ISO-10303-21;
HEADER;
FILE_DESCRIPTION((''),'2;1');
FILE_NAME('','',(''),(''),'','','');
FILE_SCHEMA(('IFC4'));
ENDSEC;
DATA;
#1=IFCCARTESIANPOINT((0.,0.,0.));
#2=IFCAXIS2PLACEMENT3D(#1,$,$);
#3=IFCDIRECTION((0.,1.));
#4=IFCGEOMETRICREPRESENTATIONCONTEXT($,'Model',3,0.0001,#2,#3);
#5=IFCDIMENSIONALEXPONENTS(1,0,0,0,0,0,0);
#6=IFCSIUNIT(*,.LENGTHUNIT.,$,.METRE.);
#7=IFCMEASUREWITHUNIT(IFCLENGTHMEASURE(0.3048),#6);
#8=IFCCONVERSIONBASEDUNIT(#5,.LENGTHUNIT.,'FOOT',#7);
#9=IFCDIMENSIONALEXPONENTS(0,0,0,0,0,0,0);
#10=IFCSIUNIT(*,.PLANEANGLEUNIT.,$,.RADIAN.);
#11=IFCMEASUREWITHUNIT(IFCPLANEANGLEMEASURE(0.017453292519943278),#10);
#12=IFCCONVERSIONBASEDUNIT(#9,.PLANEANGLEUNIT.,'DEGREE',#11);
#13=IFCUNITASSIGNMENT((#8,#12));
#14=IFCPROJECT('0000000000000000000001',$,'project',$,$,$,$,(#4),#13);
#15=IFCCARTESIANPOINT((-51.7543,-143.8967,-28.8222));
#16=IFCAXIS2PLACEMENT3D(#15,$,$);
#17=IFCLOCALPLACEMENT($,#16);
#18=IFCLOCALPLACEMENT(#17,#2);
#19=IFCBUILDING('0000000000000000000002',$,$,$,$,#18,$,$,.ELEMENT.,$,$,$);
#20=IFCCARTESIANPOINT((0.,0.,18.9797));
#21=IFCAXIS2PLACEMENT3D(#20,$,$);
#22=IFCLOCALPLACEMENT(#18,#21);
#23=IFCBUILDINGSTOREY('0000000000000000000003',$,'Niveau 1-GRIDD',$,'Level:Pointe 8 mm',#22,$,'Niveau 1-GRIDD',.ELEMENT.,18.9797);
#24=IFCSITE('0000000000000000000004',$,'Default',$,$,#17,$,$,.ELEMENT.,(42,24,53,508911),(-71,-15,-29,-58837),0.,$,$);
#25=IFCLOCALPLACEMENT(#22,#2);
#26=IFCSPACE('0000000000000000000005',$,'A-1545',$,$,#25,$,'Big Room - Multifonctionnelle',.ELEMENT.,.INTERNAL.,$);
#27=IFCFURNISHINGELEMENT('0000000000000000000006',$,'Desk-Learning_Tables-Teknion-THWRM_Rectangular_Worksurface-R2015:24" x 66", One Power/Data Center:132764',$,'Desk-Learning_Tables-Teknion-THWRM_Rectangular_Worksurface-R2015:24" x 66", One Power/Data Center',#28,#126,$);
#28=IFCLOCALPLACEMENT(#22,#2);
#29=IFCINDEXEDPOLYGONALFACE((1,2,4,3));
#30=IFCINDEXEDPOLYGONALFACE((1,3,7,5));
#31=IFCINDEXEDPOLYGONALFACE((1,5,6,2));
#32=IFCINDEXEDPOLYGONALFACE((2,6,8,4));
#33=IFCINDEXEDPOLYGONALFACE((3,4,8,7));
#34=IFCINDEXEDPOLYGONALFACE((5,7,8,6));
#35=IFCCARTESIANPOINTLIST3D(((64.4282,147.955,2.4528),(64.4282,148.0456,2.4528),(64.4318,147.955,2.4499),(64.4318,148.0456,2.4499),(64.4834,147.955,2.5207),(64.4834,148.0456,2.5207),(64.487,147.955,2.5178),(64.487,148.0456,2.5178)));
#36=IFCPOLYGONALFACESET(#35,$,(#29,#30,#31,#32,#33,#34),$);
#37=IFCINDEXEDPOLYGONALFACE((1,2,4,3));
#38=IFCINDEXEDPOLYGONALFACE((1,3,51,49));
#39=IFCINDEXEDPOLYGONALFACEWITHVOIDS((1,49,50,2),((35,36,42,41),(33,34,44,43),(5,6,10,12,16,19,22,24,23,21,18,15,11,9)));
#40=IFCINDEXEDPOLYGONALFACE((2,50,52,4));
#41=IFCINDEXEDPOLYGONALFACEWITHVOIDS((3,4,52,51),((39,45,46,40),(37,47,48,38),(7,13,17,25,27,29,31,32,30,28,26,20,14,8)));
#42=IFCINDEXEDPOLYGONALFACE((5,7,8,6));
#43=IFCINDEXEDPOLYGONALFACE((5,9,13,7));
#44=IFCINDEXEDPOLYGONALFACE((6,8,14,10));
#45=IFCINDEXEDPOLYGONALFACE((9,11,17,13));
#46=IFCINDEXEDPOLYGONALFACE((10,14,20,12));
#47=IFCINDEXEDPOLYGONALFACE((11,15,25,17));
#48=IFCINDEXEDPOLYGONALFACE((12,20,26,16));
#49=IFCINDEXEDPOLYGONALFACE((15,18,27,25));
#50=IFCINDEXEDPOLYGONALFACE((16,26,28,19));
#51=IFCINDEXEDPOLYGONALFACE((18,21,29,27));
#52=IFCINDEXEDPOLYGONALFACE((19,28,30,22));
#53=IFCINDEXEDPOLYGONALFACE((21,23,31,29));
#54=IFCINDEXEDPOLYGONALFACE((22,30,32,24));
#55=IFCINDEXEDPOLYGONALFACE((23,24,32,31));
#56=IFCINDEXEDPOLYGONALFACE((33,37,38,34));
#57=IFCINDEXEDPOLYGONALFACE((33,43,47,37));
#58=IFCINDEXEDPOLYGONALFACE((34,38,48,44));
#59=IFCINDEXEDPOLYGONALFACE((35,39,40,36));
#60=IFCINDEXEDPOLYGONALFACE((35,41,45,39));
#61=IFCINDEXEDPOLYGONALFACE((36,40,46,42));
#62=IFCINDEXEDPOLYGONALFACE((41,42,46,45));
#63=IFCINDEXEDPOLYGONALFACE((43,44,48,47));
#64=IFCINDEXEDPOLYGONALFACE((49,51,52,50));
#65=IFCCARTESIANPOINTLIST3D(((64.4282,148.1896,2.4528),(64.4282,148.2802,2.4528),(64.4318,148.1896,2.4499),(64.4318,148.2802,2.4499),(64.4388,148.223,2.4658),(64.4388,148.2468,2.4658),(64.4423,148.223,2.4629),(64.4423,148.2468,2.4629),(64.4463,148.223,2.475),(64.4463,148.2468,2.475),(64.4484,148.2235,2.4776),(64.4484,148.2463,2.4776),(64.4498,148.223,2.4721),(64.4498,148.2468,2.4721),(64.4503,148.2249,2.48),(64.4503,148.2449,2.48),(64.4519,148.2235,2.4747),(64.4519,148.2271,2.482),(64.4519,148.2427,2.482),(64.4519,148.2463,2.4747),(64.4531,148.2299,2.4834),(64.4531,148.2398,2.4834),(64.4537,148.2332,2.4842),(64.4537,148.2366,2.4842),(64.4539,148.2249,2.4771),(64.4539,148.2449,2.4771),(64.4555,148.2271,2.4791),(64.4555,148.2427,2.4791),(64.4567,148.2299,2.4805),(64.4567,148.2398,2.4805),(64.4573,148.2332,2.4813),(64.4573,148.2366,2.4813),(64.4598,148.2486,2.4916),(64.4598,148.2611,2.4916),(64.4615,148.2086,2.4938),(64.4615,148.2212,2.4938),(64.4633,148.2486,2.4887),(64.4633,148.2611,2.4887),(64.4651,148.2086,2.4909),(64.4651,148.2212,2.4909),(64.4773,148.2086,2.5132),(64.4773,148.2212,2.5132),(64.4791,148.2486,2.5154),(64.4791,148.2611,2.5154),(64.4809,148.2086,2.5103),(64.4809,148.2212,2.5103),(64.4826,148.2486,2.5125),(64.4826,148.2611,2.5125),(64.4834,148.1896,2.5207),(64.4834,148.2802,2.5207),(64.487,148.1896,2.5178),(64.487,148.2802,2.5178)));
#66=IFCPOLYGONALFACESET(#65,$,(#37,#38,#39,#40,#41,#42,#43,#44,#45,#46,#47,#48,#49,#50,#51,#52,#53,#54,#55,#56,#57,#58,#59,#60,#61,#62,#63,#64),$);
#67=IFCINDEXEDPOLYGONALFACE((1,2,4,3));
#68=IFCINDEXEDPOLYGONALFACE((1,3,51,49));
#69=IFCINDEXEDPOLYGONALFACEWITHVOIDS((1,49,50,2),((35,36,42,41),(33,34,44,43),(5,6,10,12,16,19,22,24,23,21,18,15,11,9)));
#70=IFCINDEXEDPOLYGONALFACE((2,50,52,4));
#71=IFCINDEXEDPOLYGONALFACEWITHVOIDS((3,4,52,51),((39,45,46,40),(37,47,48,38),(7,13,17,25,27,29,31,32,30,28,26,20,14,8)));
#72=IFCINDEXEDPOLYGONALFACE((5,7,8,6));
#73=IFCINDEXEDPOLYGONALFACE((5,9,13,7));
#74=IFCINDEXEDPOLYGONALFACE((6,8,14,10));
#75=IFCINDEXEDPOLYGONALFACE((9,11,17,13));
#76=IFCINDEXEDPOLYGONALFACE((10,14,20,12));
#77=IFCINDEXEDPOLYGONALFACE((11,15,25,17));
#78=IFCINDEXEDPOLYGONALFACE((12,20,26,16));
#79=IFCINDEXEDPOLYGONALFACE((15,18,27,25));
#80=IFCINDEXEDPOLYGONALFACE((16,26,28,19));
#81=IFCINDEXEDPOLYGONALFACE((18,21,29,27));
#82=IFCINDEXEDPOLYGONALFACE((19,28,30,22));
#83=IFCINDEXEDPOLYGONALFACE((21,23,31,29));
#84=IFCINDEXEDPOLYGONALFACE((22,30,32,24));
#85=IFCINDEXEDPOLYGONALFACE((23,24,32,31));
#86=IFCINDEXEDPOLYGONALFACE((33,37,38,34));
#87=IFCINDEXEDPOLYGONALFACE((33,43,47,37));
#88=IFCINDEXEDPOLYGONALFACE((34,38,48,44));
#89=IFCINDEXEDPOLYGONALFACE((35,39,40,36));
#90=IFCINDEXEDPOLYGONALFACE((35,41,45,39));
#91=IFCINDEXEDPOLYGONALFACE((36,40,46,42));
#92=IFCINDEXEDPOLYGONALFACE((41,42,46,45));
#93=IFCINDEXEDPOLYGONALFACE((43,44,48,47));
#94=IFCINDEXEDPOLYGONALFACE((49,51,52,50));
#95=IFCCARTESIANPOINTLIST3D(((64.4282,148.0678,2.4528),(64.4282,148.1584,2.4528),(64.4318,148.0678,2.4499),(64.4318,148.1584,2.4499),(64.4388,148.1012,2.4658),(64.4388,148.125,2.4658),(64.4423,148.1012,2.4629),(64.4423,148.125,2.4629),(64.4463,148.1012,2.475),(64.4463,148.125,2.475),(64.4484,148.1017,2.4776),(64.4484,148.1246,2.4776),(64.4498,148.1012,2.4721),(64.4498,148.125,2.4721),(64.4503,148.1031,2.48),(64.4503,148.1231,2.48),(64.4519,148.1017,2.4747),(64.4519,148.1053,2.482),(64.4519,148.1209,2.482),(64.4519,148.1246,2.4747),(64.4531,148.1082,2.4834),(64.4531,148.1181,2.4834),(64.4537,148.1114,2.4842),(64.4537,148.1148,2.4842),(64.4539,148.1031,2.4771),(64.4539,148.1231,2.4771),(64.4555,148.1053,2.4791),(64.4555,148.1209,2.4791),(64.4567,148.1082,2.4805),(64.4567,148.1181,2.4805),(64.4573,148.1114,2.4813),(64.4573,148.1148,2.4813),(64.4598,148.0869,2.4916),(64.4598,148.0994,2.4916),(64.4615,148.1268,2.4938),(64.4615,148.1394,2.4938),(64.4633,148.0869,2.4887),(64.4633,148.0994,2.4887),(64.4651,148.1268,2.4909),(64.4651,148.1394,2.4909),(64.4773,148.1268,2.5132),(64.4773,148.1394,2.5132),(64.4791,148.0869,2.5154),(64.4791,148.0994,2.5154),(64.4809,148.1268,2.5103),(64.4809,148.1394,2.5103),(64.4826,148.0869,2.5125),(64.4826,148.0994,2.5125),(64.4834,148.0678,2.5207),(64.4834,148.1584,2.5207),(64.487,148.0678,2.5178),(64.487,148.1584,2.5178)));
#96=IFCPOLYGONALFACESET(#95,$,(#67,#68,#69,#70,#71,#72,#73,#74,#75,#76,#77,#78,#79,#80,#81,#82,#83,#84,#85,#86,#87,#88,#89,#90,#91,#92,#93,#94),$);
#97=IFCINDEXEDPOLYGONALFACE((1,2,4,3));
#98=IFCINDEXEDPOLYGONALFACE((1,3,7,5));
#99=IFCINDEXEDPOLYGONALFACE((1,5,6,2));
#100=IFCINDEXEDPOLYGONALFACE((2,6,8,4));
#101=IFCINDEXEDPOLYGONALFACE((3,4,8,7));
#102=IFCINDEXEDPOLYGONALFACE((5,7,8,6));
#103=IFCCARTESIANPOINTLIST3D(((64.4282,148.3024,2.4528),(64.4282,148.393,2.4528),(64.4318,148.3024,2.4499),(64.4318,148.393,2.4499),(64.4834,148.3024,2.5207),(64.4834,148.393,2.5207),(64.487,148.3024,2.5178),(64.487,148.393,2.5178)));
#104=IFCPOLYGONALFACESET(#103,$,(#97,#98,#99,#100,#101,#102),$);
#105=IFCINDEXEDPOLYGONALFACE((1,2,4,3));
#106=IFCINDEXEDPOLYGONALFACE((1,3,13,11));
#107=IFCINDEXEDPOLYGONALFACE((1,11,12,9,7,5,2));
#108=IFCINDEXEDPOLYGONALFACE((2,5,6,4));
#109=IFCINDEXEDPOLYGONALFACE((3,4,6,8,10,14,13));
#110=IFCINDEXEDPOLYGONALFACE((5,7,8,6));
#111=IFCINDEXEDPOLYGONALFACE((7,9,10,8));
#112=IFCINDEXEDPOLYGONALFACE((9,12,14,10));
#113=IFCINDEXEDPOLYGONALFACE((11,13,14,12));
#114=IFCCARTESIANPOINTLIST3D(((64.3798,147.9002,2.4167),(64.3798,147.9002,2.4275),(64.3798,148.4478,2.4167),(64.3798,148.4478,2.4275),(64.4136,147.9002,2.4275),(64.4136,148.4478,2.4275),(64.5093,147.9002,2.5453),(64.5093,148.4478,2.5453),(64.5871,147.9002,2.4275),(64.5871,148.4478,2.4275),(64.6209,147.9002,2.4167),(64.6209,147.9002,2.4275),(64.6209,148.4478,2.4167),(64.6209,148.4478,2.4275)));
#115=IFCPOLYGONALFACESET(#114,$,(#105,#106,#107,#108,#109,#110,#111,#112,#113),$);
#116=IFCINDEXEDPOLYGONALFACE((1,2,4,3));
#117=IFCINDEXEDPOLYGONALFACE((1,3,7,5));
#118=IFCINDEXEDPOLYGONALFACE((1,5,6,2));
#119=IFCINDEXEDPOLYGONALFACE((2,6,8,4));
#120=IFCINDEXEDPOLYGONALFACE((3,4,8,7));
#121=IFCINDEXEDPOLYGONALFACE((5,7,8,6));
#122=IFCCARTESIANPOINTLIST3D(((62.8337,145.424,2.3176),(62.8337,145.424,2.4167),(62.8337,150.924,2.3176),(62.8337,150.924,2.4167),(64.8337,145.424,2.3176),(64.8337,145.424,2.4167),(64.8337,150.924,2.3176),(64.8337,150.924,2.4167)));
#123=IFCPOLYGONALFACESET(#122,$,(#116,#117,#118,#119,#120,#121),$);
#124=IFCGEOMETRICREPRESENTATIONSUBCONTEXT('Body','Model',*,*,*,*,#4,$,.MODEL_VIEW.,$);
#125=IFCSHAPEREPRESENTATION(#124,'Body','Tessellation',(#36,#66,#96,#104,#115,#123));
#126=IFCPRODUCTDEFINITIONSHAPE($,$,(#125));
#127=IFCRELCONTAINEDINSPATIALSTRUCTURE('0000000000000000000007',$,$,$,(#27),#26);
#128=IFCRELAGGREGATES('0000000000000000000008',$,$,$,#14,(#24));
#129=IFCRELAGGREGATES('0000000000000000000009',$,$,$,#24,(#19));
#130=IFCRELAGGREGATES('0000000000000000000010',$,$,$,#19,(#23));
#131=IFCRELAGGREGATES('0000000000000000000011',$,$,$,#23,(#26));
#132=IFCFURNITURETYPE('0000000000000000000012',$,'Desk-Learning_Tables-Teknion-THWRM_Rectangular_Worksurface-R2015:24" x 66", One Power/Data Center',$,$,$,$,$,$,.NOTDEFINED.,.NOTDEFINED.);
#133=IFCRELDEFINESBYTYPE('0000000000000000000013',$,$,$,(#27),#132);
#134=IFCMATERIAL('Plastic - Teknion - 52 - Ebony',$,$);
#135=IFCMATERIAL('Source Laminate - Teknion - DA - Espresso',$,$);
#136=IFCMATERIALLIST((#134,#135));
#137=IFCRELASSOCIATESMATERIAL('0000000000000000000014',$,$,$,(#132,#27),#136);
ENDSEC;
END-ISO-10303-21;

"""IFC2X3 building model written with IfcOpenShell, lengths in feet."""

from ifc_helpers import new_model, entity, si_unit, converted_unit, direction, frame, frame_2d, origin, place, context, subcontext, project, spatial, polyline, circle_curve, parameter, trimmed, segment, composite_curve, rectangle, outline, extrude, source, transform, mapped, material, material_list, type_object, type_shapes, element, save


model = new_model("IFC2X3")

# Units and contexts
model_context = context("Model", 3, precision=0.0001, world=origin(), true_north=direction((0.0, 1.0)))
body_context = subcontext(model_context, "Body", "Model", "MODEL_VIEW")
ifc_project = project(units=[converted_unit("LENGTHUNIT", "FOOT", entity("IfcLengthMeasure", 0.3048), si_unit("LENGTHUNIT", "METRE"), dimensions=[1, 0, 0, 0, 0, 0, 0]), converted_unit("PLANEANGLEUNIT", "DEGREE", entity("IfcPlaneAngleMeasure", 0.017453292519943278), si_unit("PLANEANGLEUNIT", "RADIAN"), dimensions=[0, 0, 0, 0, 0, 0, 0])], contexts=[model_context])

# Site, building, storey
site_placement = place(None, frame((-51.7543, -143.8967, -28.8222)))
site = spatial("IfcSite", under=ifc_project, at=site_placement, Name="Default", CompositionType="ELEMENT", RefLatitude=(42, 24, 53, 508911), RefLongitude=(-71, -15, -29, -58837), RefElevation=0.0)
building_placement = place(site_placement, origin())
building = spatial("IfcBuilding", under=site, at=building_placement, CompositionType="ELEMENT")
storey_placement = place(building_placement, frame((0.0, 0.0, 18.9797)))
storey = spatial("IfcBuildingStorey", under=building, at=storey_placement, Name="Niveau 1-GRIDD", ObjectType="Level:Pointe 8 mm", LongName="Niveau 1-GRIDD", CompositionType="ELEMENT", Elevation=18.9797)

# Shared definitions
space_placement = place(storey_placement, origin())
space = spatial("IfcSpace", under=storey, at=space_placement, Name="A-1545", LongName="Big Room - Multifonctionnelle", CompositionType="ELEMENT", InteriorOrExteriorSpace="INTERNAL")

# Furnishing element
ifc_material_1 = material(Name="Plastic - Teknion - 52 - Ebony")
ifc_material_2 = material(Name="Source Laminate - Teknion - DA - Espresso")
ifc_material_list_1 = material_list([ifc_material_1, ifc_material_2])
furniture_type_1 = type_object("IfcFurnitureType", Name="Desk-Learning_Tables-Teknion-THWRM_Rectangular_Worksurface-R2015:24\" x 66\", One Power/Data Center", AssemblyPlace="NOTDEFINED", material=ifc_material_list_1)
shared_shape_1 = source(origin(), body_context, "Body", "SweptSolid", [
    extrude(rectangle(XDim=0.0875, YDim=0.0046, at=frame_2d((0.0, 0.0), x_axis=(0.0, 1.0))), frame((0.1284, 0.6239, 2.4853), z_axis=(1.0, 0.0, 0.0), x_axis=(0.0, 0.776046, -0.630676)), (0.0, 0.0, 1.0), 0.0906),
    extrude(outline(polyline([(-0.0453, -0.0438), (0.0453, -0.0438), (0.0453, 0.0438), (-0.0453, 0.0438), (-0.0453, -0.0438)]), holes=[polyline([(-0.0262, -0.0063), (-0.0137, -0.0063), (-0.0137, -0.0369), (-0.0262, -0.0369), (-0.0262, -0.0063)]), polyline([(0.0137, -0.0341), (0.0137, -0.0091), (0.0262, -0.0091), (0.0262, -0.0341), (0.0137, -0.0341)]), composite_curve([segment(polyline([(-0.0119, 0.027), (0.0119, 0.027)]), True, "CONTINUOUS"), segment(polyline([(0.0119, 0.027), (0.0119, 0.0151)]), True, "CONTINUOUS"), segment(trimmed(circle_curve(frame_2d((0.0, 0.0151), x_axis=(0.0, -1.0)), 0.0119), [parameter(270.0)], [parameter(90.0)], True, "PARAMETER"), False, "CONTINUOUS"), segment(polyline([(-0.0119, 0.0151), (-0.0119, 0.027)]), True, "CONTINUOUS")], self_intersect=False)]), frame((-0.0609, 0.6221, 2.4867), z_axis=(0.0, 0.776046, -0.630676), x_axis=(1.0, 0.0, 0.0)), (0.0, 0.0, 1.0), 0.0046),
    extrude(outline(polyline([(-0.0438, -0.0453), (0.0438, -0.0453), (0.0438, 0.0453), (-0.0438, 0.0453), (-0.0438, -0.0453)]), holes=[polyline([(-0.0063, -0.0262), (-0.0369, -0.0262), (-0.0369, -0.0137), (-0.0063, -0.0137), (-0.0063, -0.0262)]), polyline([(-0.0341, 0.0137), (-0.0341, 0.0262), (-0.0091, 0.0262), (-0.0091, 0.0137), (-0.0341, 0.0137)]), composite_curve([segment(polyline([(0.027, -0.0119), (0.0151, -0.0119)]), True, "CONTINUOUS"), segment(trimmed(circle_curve(frame_2d((0.0151, 0.0), x_axis=(-1.0, 0.0)), 0.0119), [parameter(270.0)], [parameter(90.0)], True, "PARAMETER"), False, "CONTINUOUS"), segment(polyline([(0.0151, 0.0119), (0.027, 0.0119)]), True, "CONTINUOUS"), segment(polyline([(0.027, 0.0119), (0.027, -0.0119)]), True, "CONTINUOUS")], self_intersect=False)]), frame((0.0609, 0.6221, 2.4867), z_axis=(0.0, 0.776046, -0.630676), x_axis=(0.0, -0.630676, -0.776046)), (0.0, 0.0, 1.0), 0.0046),
    extrude(rectangle(XDim=0.0875, YDim=0.0046, at=frame_2d((0.0, 0.0), x_axis=(0.0, 1.0))), frame((-0.219, 0.6239, 2.4853), z_axis=(1.0, 0.0, 0.0), x_axis=(0.0, 0.776046, -0.630676)), (0.0, 0.0, 1.0), 0.0906),
    extrude(outline(polyline([(-0.0586, -0.0638), (0.0826, -0.0638), (0.0371, 0.0811), (0.0557, 0.1093), (0.0467, 0.1152), (-0.0862, -0.086), (-0.0772, -0.092), (-0.0586, -0.0638)])), frame((-0.2738, 0.6679, 2.4412), z_axis=(1.0, 0.0, 0.0), x_axis=(0.0, -0.551103, 0.834437)), (0.0, 0.0, 1.0), 0.5475),
    extrude(rectangle(XDim=5.5, YDim=2.0, at=frame_2d((0.0, 0.0), x_axis=(1.0, 0.0))), frame((0.0, 0.0, 2.3176), z_axis=(0.0, 0.0, 1.0), x_axis=(-1.0, 0.0, 0.0)), (0.0, 0.0, 1.0), 0.0991),
])
type_shapes(furniture_type_1, [shared_shape_1])
for number, where, z_axis, x_axis, name in (
    (1, (63.8337, 148.174, 0.0), (0.0, 0.0, 1.0), (0.0, -1.0, 0.0), "Desk-Learning_Tables-Teknion-THWRM_Rectangular_Worksurface-R2015:24\" x 66\", One Power/Data Center:132764"),
):
    element("IfcFurnishingElement", number, at=place(space_placement, frame(where, z_axis=z_axis, x_axis=x_axis)), inside=space, type_object=furniture_type_1, material=ifc_material_list_1, Name=name, ObjectType="Desk-Learning_Tables-Teknion-THWRM_Rectangular_Worksurface-R2015:24\" x 66\", One Power/Data Center", context=body_context, shape_type="MappedRepresentation", body=[
        mapped(shared_shape_1, transform((0.0, 0.0, 0.0), scale=1.0)),
    ])

save(model, "model.ifc")
